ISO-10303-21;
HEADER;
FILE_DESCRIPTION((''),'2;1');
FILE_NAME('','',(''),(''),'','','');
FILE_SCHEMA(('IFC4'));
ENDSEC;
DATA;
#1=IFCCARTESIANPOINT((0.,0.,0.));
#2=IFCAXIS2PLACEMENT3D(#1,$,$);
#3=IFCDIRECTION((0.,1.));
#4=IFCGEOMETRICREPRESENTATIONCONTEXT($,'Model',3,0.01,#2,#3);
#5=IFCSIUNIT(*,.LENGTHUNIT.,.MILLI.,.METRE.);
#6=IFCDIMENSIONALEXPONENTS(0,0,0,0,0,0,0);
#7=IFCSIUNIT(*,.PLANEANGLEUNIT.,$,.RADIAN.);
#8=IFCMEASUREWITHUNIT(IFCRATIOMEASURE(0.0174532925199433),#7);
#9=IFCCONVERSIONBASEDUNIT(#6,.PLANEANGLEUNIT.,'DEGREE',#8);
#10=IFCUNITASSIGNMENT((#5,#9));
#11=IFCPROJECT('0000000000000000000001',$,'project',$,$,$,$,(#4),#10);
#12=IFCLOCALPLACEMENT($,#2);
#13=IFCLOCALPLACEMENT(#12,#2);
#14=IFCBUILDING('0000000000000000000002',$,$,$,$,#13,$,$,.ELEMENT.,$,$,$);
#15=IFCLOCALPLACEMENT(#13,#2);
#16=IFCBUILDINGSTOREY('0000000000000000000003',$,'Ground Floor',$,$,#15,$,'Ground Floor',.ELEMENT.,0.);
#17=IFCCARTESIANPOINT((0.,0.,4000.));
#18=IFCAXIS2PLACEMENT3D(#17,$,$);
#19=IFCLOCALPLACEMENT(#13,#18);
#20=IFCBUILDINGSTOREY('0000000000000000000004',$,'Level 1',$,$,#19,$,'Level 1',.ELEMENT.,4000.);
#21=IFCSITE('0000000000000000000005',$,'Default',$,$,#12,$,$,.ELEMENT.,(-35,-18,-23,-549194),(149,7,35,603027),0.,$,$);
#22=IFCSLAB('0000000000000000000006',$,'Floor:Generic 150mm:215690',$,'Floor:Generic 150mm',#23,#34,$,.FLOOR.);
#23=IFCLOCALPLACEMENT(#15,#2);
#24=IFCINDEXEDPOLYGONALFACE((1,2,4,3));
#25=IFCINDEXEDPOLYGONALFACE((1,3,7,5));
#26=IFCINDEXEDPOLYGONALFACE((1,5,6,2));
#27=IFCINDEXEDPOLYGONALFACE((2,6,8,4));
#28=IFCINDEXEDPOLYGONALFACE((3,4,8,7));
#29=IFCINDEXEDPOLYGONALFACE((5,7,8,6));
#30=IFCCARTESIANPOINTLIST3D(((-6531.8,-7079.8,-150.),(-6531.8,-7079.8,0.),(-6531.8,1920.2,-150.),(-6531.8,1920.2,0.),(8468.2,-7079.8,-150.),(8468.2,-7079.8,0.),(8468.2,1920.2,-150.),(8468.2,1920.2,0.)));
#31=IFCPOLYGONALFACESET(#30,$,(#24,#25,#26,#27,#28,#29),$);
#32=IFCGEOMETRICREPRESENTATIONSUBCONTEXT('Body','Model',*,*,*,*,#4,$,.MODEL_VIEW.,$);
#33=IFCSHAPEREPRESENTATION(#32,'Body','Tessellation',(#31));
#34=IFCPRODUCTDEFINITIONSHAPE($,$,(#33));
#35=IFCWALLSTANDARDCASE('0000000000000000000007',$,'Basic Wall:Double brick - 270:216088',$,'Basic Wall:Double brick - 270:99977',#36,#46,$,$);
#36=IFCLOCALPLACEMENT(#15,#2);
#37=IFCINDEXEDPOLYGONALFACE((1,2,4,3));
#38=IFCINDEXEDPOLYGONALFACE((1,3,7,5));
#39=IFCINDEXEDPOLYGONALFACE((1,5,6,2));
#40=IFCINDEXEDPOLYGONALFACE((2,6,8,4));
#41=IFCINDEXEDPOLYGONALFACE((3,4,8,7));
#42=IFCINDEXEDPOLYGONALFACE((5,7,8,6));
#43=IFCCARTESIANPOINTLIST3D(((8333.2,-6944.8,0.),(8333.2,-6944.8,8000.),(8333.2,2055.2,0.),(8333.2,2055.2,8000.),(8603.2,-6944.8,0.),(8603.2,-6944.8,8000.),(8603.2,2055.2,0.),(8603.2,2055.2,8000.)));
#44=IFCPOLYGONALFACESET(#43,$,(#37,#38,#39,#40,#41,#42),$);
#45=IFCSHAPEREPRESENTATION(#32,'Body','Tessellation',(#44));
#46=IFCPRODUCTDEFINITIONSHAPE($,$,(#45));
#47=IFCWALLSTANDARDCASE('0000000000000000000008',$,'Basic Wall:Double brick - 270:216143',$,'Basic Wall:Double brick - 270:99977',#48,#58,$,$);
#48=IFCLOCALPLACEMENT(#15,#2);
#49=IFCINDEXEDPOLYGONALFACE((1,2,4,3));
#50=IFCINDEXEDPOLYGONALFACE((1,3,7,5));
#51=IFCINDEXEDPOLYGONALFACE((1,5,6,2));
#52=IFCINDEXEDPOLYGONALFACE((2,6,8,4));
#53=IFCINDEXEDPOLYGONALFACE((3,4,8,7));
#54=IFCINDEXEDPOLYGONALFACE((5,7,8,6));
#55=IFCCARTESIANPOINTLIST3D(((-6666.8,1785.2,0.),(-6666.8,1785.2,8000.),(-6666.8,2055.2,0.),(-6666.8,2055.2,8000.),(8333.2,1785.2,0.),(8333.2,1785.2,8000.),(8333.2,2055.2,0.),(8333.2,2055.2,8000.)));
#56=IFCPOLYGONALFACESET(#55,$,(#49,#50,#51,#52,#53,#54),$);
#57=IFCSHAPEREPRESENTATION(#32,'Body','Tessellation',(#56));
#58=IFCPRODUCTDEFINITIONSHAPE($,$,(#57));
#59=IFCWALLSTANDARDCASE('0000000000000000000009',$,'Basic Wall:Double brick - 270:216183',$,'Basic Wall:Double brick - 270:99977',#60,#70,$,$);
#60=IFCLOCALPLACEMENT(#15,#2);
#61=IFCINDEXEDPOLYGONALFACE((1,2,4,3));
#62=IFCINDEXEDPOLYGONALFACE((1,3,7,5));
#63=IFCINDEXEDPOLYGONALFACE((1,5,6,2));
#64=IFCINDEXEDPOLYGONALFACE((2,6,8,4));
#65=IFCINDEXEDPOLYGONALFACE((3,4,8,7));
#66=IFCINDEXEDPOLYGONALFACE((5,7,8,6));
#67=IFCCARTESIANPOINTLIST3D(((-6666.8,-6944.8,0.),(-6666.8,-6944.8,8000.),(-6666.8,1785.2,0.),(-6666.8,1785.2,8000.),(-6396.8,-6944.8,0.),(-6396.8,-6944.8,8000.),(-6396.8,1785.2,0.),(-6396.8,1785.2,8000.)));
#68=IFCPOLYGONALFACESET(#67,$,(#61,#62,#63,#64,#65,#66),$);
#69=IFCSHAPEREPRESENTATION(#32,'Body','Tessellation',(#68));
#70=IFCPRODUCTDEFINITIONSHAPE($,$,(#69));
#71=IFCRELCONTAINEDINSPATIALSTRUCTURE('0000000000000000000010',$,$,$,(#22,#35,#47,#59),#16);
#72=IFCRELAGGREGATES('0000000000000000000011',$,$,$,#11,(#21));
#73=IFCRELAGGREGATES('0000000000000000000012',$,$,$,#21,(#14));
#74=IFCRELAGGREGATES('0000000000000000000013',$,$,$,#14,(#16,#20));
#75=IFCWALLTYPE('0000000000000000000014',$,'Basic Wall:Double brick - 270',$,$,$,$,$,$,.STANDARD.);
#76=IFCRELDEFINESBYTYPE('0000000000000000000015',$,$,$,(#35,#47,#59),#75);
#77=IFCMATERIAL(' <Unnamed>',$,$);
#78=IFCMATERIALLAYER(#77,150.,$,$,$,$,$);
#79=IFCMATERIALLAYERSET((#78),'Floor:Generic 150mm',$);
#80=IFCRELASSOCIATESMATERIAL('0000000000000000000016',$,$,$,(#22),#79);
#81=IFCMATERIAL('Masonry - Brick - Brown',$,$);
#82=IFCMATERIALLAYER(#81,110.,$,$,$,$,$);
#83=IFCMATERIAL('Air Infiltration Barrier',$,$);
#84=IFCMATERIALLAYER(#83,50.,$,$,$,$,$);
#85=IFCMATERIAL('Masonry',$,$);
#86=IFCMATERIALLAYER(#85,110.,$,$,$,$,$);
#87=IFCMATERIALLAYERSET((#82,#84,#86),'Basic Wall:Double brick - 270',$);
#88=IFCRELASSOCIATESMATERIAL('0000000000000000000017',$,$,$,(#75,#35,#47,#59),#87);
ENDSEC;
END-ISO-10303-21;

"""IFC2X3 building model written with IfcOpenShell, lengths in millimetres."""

from ifc_helpers import new_model, entity, si_unit, converted_unit, direction, frame, frame_2d, origin, origin_2d_with_axis, place, context, subcontext, project, spatial, rectangle, extrude, material, layer, layer_set, layer_usage, type_object, element, save


model = new_model("IFC2X3")

# Units and contexts
model_context = context("Model", 3, precision=0.01, world=origin(), true_north=direction((0.0, 1.0)))
body_context = subcontext(model_context, "Body", "Model", "MODEL_VIEW")
ifc_project = project(units=[si_unit("LENGTHUNIT", "METRE", prefix="MILLI"), converted_unit("PLANEANGLEUNIT", "DEGREE", entity("IfcRatioMeasure", 0.0174532925199433), si_unit("PLANEANGLEUNIT", "RADIAN"), dimensions=[0, 0, 0, 0, 0, 0, 0])], contexts=[model_context])

# Site, building, storey
site_placement = place(None, origin())
site = spatial("IfcSite", under=ifc_project, at=site_placement, Name="Default", CompositionType="ELEMENT", RefLatitude=(-35, -18, -23, -549194), RefLongitude=(149, 7, 35, 603027), RefElevation=0.0)
building_placement = place(site_placement, origin())
building = spatial("IfcBuilding", under=site, at=building_placement, CompositionType="ELEMENT")
storey_1_placement = place(building_placement, origin())
storey_1 = spatial("IfcBuildingStorey", under=building, at=storey_1_placement, Name="Ground Floor", LongName="Ground Floor", CompositionType="ELEMENT", Elevation=0.0)

# Slab
ifc_material_1 = material(Name=" <Unnamed>")
ifc_layer_1 = layer(ifc_material_1, 150.0)
ifc_layer_set_1 = layer_set([ifc_layer_1], Name="Floor:Generic 150mm")
ifc_layer_usage_1 = layer_usage(ifc_layer_set_1, "AXIS3", "POSITIVE", 0.0)
slab_placement = place(storey_1_placement, origin())
element("IfcSlab", 1, at=slab_placement, inside=storey_1, material=ifc_layer_usage_1, Name="Floor:Generic 150mm:215690", ObjectType="Floor:Generic 150mm", PredefinedType="FLOOR", context=body_context, shape_type="SweptSolid", body=[
    extrude(rectangle(XDim=9000.0, YDim=15000.0, at=origin_2d_with_axis()), frame((968.2, -2579.8, 0.0), z_axis=(0.0, 0.0, -1.0), x_axis=(0.0, 1.0, 0.0)), (0.0, 0.0, 1.0), 150.0),
])

# Shared definitions
ifc_material_2 = material(Name="Masonry - Brick - Brown")
ifc_layer_2 = layer(ifc_material_2, 110.0)
ifc_material_3 = material(Name="Air Infiltration Barrier")
ifc_layer_3 = layer(ifc_material_3, 50.0)
ifc_material_4 = material(Name="Masonry")
ifc_layer_4 = layer(ifc_material_4, 110.0)
ifc_layer_set_2 = layer_set([ifc_layer_2, ifc_layer_3, ifc_layer_4], Name="Basic Wall:Double brick - 270")
wall_type = type_object("IfcWallType", Name="Basic Wall:Double brick - 270", PredefinedType="STANDARD", material=ifc_layer_set_2)

# Shared definitions
storey_2_placement = place(building_placement, frame((0.0, 0.0, 4000.0)))
storey_2 = spatial("IfcBuildingStorey", under=building, at=storey_2_placement, Name="Level 1", LongName="Level 1", CompositionType="ELEMENT", Elevation=4000.0)

# Walls
ifc_layer_usage_2 = layer_usage(ifc_layer_set_2, "AXIS2", "NEGATIVE", 135.0)
wall_1_placement = place(storey_1_placement, frame((8468.2, -6944.8, 0.0), z_axis=(0.0, 0.0, 1.0), x_axis=(0.0, 1.0, 0.0)))
element("IfcWallStandardCase", 2, at=wall_1_placement, inside=storey_1, type_object=wall_type, material=ifc_layer_usage_2, Name="Basic Wall:Double brick - 270:216088", ObjectType="Basic Wall:Double brick - 270:99977", context=body_context, shape_type="SweptSolid", body=[
    extrude(rectangle(XDim=9000.0, YDim=270.0, at=frame_2d((4500.0, 0.0), x_axis=(-1.0, 0.0))), origin(), (0.0, 0.0, 1.0), 8000.0),
])
ifc_layer_usage_3 = layer_usage(ifc_layer_set_2, "AXIS2", "NEGATIVE", 135.0)
wall_2_placement = place(storey_1_placement, frame((8333.2, 1920.2, 0.0), z_axis=(0.0, 0.0, 1.0), x_axis=(-1.0, 0.0, 0.0)))
element("IfcWallStandardCase", 3, at=wall_2_placement, inside=storey_1, type_object=wall_type, material=ifc_layer_usage_3, Name="Basic Wall:Double brick - 270:216143", ObjectType="Basic Wall:Double brick - 270:99977", context=body_context, shape_type="SweptSolid", body=[
    extrude(rectangle(XDim=15000.0, YDim=270.0, at=frame_2d((7500.0, 0.0), x_axis=(-1.0, 0.0))), origin(), (0.0, 0.0, 1.0), 8000.0),
])
ifc_layer_usage_4 = layer_usage(ifc_layer_set_2, "AXIS2", "NEGATIVE", 135.0)
wall_3_placement = place(storey_1_placement, frame((-6531.8, 1785.2, 0.0), z_axis=(0.0, 0.0, 1.0), x_axis=(0.0, -1.0, 0.0)))
element("IfcWallStandardCase", 4, at=wall_3_placement, inside=storey_1, type_object=wall_type, material=ifc_layer_usage_4, Name="Basic Wall:Double brick - 270:216183", ObjectType="Basic Wall:Double brick - 270:99977", context=body_context, shape_type="SweptSolid", body=[
    extrude(rectangle(XDim=8730.0, YDim=270.0, at=frame_2d((4365.0, 0.0), x_axis=(-1.0, 0.0))), origin(), (0.0, 0.0, 1.0), 8000.0),
])

save(model, "model.ifc")
